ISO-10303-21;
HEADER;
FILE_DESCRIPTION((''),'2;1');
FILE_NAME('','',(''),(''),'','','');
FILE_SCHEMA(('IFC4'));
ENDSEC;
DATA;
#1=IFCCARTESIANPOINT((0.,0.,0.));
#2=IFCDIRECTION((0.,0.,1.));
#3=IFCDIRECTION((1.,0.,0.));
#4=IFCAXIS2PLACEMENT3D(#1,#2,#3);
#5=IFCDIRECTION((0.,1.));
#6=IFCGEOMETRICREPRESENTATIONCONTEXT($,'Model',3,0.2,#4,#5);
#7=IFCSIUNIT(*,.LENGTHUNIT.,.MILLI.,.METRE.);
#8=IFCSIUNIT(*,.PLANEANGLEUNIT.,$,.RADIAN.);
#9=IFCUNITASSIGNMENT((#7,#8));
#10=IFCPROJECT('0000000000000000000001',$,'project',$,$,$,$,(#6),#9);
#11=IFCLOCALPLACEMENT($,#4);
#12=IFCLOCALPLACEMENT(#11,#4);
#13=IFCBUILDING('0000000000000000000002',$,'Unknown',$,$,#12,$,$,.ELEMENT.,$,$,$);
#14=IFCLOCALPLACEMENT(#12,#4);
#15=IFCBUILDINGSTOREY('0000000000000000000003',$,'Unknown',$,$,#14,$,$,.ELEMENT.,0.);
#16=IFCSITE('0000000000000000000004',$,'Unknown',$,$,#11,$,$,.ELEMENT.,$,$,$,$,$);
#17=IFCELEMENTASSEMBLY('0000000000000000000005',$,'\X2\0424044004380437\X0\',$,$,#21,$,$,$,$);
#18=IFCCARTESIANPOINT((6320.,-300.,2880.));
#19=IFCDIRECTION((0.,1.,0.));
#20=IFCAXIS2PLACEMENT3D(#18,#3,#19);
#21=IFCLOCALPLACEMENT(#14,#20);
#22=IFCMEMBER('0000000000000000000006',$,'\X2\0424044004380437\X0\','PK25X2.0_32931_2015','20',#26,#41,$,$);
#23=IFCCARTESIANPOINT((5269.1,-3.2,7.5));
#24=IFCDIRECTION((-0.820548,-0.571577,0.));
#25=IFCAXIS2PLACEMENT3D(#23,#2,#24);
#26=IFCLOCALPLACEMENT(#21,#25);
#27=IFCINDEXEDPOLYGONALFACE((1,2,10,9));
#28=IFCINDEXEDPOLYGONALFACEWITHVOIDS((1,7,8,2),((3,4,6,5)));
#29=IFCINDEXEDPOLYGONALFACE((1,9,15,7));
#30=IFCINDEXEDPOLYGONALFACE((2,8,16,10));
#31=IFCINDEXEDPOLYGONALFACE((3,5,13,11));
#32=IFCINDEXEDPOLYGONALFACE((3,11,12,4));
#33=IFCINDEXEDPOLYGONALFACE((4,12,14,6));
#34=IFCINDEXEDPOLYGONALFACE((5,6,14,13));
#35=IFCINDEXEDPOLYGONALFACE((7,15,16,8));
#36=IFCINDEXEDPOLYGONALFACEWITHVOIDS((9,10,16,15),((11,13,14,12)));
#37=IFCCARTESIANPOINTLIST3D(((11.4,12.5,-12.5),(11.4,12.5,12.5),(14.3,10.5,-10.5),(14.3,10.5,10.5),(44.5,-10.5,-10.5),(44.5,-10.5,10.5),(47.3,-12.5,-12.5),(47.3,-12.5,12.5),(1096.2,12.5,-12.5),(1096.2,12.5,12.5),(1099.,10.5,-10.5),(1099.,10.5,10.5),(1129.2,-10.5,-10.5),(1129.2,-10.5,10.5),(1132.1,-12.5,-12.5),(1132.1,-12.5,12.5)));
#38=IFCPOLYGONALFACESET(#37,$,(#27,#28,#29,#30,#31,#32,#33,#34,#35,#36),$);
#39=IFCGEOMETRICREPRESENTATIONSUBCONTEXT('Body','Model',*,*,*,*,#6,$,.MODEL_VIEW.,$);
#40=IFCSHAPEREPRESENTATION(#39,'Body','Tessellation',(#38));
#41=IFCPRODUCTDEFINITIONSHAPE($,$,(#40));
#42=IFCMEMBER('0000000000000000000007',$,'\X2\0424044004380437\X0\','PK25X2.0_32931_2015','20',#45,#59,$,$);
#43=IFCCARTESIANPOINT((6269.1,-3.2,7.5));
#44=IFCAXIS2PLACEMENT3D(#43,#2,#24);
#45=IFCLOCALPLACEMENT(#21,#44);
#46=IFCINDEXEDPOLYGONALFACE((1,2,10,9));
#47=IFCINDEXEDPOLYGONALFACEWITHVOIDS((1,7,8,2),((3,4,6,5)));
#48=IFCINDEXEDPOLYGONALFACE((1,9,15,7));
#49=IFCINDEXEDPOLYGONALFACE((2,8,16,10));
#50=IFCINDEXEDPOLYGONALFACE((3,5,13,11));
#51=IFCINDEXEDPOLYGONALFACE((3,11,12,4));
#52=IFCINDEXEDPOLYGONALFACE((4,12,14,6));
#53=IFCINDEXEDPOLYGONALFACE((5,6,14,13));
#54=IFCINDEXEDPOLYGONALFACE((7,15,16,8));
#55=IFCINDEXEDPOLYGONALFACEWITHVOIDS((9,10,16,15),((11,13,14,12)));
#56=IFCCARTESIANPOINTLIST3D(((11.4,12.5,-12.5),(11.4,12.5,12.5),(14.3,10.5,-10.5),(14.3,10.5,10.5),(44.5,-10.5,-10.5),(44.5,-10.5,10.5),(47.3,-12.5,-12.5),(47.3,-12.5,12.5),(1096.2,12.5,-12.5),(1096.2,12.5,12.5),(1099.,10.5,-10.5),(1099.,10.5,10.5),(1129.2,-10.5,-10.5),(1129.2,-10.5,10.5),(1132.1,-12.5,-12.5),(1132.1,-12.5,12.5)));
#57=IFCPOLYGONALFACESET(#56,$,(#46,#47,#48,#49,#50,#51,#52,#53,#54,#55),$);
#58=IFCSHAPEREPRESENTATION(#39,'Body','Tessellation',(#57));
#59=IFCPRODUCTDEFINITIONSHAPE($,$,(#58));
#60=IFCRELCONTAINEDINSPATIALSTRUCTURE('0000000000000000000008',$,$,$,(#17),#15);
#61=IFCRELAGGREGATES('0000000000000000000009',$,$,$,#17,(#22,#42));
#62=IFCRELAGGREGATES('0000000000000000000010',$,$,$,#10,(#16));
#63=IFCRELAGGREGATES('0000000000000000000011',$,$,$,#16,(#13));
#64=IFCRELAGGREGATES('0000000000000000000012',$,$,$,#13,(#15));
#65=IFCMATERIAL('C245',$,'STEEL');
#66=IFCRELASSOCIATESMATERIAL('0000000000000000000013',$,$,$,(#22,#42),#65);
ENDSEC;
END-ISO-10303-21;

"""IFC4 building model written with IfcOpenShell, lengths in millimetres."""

from ifc_helpers import new_model, si_unit, direction, frame, origin_with_axes, place, context, subcontext, project, spatial, line, indexed_curve, outline, extrude, material, element, aggregate, save


model = new_model("IFC4")

# Units and contexts
model_context = context("Model", 3, precision=0.2, world=origin_with_axes(), true_north=direction((0.0, 1.0)))
body_context = subcontext(model_context, "Body", "Model", "MODEL_VIEW")
ifc_project = project(units=[si_unit("LENGTHUNIT", "METRE", prefix="MILLI"), si_unit("PLANEANGLEUNIT", "RADIAN")], contexts=[model_context])

# Site, building, storey
site_placement = place(None, origin_with_axes())
site = spatial("IfcSite", under=ifc_project, at=site_placement, Name="Unknown", CompositionType="ELEMENT")
building_placement = place(site_placement, origin_with_axes())
building = spatial("IfcBuilding", under=site, at=building_placement, Name="Unknown", CompositionType="ELEMENT")
storey_placement = place(building_placement, origin_with_axes())
storey = spatial("IfcBuildingStorey", under=building, at=storey_placement, Name="Unknown", CompositionType="ELEMENT", Elevation=0.0)

# Shared definitions
ifc_material_1 = material(Name="C245", Category="STEEL")

# Element assembly, members, voiding features
assembly_1_placement = place(storey_placement, frame((6320.0, -300.0, 2880.0), z_axis=(1.0, 0.0, 0.0), x_axis=(0.0, 1.0, 0.0)))
assembly_1 = element("IfcElementAssembly", 1, at=assembly_1_placement, inside=storey, Name="Фриз")
member_1_placement = place(assembly_1_placement, frame((5269.1, -3.2, 7.5), z_axis=(0.0, 0.0, 1.0), x_axis=(-0.820548, -0.571577, 0.0)))
member_1 = element("IfcMember", 2, at=member_1_placement, material=ifc_material_1, Name="Фриз", Description="PK25X2.0_32931_2015", ObjectType="20", context=body_context, shape_type="SolidModel", body=[
    extrude(outline(indexed_curve([(-12.5, -12.5), (12.5, -12.5), (12.5, 12.5), (-12.5, 12.5)], segments=[line(1, 2, 3, 4, 1)]), holes=[indexed_curve([(-10.5, -10.5), (-10.5, 10.5), (10.5, 10.5), (10.5, -10.5)], segments=[line(1, 2, 3, 4, 1)])]), frame((0.0, 0.0, 0.0), z_axis=(-1.0, 0.0, 0.0), x_axis=(0.0, 0.0, 1.0)), (0.0, 0.0, -1.0), 1143.5),
])
voiding_feature_1_placement = place(member_1_placement, frame((899.1, -630.2, -7.5), z_axis=(0.0, 0.0, 1.0), x_axis=(-0.820548, 0.571577, 0.0)))
element("IfcVoidingFeature", 3, at=voiding_feature_1_placement, cuts=member_1, Name="CUT_BEAM", ObjectType="(?)", PredefinedType="HOLE", context=body_context, shape_type="SolidModel", body=[
    extrude(outline(indexed_curve([(-20.0, -20.0), (20.0, -20.0), (20.0, 20.0), (-20.0, 20.0)], segments=[line(1, 2, 3, 4, 1)])), frame((0.0, 0.0, 0.0), z_axis=(-1.0, 0.0, 0.0), x_axis=(0.0, 0.0, 1.0)), (0.0, 0.0, -1.0), 2205.1),
])
voiding_feature_2_placement = place(member_1_placement, frame((2053.8, -630.2, -7.5), z_axis=(0.0, 0.0, 1.0), x_axis=(-0.820548, 0.571577, 0.0)))
element("IfcVoidingFeature", 4, at=voiding_feature_2_placement, cuts=member_1, Name="CUT_BEAM", ObjectType="(?)", PredefinedType="HOLE", context=body_context, shape_type="SolidModel", body=[
    extrude(outline(indexed_curve([(-20.0, -20.0), (20.0, -20.0), (20.0, 20.0), (-20.0, 20.0)], segments=[line(1, 2, 3, 4, 1)])), frame((0.0, 0.0, 0.0), z_axis=(-1.0, 0.0, 0.0), x_axis=(0.0, 0.0, 1.0)), (0.0, 0.0, -1.0), 2205.1),
])
member_2_placement = place(assembly_1_placement, frame((6269.1, -3.2, 7.5), z_axis=(0.0, 0.0, 1.0), x_axis=(-0.820548, -0.571577, 0.0)))
member_2 = element("IfcMember", 5, at=member_2_placement, material=ifc_material_1, Name="Фриз", Description="PK25X2.0_32931_2015", ObjectType="20", context=body_context, shape_type="SolidModel", body=[
    extrude(outline(indexed_curve([(-12.5, -12.5), (12.5, -12.5), (12.5, 12.5), (-12.5, 12.5)], segments=[line(1, 2, 3, 4, 1)]), holes=[indexed_curve([(-10.5, -10.5), (-10.5, 10.5), (10.5, 10.5), (10.5, -10.5)], segments=[line(1, 2, 3, 4, 1)])]), frame((0.0, 0.0, 0.0), z_axis=(-1.0, 0.0, 0.0), x_axis=(0.0, 0.0, 1.0)), (0.0, 0.0, -1.0), 1143.5),
])
voiding_feature_3_placement = place(member_2_placement, frame((899.1, -630.2, -7.5), z_axis=(0.0, 0.0, 1.0), x_axis=(-0.820548, 0.571577, 0.0)))
element("IfcVoidingFeature", 6, at=voiding_feature_3_placement, cuts=member_2, Name="CUT_BEAM", ObjectType="(?)", PredefinedType="HOLE", context=body_context, shape_type="SolidModel", body=[
    extrude(outline(indexed_curve([(-20.0, -20.0), (20.0, -20.0), (20.0, 20.0), (-20.0, 20.0)], segments=[line(1, 2, 3, 4, 1)])), frame((0.0, 0.0, 0.0), z_axis=(-1.0, 0.0, 0.0), x_axis=(0.0, 0.0, 1.0)), (0.0, 0.0, -1.0), 2205.1),
])
voiding_feature_4_placement = place(member_2_placement, frame((2053.8, -630.2, -7.5), z_axis=(0.0, 0.0, 1.0), x_axis=(-0.820548, 0.571577, 0.0)))
element("IfcVoidingFeature", 7, at=voiding_feature_4_placement, cuts=member_2, Name="CUT_BEAM", ObjectType="(?)", PredefinedType="HOLE", context=body_context, shape_type="SolidModel", body=[
    extrude(outline(indexed_curve([(-20.0, -20.0), (20.0, -20.0), (20.0, 20.0), (-20.0, 20.0)], segments=[line(1, 2, 3, 4, 1)])), frame((0.0, 0.0, 0.0), z_axis=(-1.0, 0.0, 0.0), x_axis=(0.0, 0.0, 1.0)), (0.0, 0.0, -1.0), 2205.1),
])
aggregate(assembly_1, [member_1, member_2])

save(model, "model.ifc")
